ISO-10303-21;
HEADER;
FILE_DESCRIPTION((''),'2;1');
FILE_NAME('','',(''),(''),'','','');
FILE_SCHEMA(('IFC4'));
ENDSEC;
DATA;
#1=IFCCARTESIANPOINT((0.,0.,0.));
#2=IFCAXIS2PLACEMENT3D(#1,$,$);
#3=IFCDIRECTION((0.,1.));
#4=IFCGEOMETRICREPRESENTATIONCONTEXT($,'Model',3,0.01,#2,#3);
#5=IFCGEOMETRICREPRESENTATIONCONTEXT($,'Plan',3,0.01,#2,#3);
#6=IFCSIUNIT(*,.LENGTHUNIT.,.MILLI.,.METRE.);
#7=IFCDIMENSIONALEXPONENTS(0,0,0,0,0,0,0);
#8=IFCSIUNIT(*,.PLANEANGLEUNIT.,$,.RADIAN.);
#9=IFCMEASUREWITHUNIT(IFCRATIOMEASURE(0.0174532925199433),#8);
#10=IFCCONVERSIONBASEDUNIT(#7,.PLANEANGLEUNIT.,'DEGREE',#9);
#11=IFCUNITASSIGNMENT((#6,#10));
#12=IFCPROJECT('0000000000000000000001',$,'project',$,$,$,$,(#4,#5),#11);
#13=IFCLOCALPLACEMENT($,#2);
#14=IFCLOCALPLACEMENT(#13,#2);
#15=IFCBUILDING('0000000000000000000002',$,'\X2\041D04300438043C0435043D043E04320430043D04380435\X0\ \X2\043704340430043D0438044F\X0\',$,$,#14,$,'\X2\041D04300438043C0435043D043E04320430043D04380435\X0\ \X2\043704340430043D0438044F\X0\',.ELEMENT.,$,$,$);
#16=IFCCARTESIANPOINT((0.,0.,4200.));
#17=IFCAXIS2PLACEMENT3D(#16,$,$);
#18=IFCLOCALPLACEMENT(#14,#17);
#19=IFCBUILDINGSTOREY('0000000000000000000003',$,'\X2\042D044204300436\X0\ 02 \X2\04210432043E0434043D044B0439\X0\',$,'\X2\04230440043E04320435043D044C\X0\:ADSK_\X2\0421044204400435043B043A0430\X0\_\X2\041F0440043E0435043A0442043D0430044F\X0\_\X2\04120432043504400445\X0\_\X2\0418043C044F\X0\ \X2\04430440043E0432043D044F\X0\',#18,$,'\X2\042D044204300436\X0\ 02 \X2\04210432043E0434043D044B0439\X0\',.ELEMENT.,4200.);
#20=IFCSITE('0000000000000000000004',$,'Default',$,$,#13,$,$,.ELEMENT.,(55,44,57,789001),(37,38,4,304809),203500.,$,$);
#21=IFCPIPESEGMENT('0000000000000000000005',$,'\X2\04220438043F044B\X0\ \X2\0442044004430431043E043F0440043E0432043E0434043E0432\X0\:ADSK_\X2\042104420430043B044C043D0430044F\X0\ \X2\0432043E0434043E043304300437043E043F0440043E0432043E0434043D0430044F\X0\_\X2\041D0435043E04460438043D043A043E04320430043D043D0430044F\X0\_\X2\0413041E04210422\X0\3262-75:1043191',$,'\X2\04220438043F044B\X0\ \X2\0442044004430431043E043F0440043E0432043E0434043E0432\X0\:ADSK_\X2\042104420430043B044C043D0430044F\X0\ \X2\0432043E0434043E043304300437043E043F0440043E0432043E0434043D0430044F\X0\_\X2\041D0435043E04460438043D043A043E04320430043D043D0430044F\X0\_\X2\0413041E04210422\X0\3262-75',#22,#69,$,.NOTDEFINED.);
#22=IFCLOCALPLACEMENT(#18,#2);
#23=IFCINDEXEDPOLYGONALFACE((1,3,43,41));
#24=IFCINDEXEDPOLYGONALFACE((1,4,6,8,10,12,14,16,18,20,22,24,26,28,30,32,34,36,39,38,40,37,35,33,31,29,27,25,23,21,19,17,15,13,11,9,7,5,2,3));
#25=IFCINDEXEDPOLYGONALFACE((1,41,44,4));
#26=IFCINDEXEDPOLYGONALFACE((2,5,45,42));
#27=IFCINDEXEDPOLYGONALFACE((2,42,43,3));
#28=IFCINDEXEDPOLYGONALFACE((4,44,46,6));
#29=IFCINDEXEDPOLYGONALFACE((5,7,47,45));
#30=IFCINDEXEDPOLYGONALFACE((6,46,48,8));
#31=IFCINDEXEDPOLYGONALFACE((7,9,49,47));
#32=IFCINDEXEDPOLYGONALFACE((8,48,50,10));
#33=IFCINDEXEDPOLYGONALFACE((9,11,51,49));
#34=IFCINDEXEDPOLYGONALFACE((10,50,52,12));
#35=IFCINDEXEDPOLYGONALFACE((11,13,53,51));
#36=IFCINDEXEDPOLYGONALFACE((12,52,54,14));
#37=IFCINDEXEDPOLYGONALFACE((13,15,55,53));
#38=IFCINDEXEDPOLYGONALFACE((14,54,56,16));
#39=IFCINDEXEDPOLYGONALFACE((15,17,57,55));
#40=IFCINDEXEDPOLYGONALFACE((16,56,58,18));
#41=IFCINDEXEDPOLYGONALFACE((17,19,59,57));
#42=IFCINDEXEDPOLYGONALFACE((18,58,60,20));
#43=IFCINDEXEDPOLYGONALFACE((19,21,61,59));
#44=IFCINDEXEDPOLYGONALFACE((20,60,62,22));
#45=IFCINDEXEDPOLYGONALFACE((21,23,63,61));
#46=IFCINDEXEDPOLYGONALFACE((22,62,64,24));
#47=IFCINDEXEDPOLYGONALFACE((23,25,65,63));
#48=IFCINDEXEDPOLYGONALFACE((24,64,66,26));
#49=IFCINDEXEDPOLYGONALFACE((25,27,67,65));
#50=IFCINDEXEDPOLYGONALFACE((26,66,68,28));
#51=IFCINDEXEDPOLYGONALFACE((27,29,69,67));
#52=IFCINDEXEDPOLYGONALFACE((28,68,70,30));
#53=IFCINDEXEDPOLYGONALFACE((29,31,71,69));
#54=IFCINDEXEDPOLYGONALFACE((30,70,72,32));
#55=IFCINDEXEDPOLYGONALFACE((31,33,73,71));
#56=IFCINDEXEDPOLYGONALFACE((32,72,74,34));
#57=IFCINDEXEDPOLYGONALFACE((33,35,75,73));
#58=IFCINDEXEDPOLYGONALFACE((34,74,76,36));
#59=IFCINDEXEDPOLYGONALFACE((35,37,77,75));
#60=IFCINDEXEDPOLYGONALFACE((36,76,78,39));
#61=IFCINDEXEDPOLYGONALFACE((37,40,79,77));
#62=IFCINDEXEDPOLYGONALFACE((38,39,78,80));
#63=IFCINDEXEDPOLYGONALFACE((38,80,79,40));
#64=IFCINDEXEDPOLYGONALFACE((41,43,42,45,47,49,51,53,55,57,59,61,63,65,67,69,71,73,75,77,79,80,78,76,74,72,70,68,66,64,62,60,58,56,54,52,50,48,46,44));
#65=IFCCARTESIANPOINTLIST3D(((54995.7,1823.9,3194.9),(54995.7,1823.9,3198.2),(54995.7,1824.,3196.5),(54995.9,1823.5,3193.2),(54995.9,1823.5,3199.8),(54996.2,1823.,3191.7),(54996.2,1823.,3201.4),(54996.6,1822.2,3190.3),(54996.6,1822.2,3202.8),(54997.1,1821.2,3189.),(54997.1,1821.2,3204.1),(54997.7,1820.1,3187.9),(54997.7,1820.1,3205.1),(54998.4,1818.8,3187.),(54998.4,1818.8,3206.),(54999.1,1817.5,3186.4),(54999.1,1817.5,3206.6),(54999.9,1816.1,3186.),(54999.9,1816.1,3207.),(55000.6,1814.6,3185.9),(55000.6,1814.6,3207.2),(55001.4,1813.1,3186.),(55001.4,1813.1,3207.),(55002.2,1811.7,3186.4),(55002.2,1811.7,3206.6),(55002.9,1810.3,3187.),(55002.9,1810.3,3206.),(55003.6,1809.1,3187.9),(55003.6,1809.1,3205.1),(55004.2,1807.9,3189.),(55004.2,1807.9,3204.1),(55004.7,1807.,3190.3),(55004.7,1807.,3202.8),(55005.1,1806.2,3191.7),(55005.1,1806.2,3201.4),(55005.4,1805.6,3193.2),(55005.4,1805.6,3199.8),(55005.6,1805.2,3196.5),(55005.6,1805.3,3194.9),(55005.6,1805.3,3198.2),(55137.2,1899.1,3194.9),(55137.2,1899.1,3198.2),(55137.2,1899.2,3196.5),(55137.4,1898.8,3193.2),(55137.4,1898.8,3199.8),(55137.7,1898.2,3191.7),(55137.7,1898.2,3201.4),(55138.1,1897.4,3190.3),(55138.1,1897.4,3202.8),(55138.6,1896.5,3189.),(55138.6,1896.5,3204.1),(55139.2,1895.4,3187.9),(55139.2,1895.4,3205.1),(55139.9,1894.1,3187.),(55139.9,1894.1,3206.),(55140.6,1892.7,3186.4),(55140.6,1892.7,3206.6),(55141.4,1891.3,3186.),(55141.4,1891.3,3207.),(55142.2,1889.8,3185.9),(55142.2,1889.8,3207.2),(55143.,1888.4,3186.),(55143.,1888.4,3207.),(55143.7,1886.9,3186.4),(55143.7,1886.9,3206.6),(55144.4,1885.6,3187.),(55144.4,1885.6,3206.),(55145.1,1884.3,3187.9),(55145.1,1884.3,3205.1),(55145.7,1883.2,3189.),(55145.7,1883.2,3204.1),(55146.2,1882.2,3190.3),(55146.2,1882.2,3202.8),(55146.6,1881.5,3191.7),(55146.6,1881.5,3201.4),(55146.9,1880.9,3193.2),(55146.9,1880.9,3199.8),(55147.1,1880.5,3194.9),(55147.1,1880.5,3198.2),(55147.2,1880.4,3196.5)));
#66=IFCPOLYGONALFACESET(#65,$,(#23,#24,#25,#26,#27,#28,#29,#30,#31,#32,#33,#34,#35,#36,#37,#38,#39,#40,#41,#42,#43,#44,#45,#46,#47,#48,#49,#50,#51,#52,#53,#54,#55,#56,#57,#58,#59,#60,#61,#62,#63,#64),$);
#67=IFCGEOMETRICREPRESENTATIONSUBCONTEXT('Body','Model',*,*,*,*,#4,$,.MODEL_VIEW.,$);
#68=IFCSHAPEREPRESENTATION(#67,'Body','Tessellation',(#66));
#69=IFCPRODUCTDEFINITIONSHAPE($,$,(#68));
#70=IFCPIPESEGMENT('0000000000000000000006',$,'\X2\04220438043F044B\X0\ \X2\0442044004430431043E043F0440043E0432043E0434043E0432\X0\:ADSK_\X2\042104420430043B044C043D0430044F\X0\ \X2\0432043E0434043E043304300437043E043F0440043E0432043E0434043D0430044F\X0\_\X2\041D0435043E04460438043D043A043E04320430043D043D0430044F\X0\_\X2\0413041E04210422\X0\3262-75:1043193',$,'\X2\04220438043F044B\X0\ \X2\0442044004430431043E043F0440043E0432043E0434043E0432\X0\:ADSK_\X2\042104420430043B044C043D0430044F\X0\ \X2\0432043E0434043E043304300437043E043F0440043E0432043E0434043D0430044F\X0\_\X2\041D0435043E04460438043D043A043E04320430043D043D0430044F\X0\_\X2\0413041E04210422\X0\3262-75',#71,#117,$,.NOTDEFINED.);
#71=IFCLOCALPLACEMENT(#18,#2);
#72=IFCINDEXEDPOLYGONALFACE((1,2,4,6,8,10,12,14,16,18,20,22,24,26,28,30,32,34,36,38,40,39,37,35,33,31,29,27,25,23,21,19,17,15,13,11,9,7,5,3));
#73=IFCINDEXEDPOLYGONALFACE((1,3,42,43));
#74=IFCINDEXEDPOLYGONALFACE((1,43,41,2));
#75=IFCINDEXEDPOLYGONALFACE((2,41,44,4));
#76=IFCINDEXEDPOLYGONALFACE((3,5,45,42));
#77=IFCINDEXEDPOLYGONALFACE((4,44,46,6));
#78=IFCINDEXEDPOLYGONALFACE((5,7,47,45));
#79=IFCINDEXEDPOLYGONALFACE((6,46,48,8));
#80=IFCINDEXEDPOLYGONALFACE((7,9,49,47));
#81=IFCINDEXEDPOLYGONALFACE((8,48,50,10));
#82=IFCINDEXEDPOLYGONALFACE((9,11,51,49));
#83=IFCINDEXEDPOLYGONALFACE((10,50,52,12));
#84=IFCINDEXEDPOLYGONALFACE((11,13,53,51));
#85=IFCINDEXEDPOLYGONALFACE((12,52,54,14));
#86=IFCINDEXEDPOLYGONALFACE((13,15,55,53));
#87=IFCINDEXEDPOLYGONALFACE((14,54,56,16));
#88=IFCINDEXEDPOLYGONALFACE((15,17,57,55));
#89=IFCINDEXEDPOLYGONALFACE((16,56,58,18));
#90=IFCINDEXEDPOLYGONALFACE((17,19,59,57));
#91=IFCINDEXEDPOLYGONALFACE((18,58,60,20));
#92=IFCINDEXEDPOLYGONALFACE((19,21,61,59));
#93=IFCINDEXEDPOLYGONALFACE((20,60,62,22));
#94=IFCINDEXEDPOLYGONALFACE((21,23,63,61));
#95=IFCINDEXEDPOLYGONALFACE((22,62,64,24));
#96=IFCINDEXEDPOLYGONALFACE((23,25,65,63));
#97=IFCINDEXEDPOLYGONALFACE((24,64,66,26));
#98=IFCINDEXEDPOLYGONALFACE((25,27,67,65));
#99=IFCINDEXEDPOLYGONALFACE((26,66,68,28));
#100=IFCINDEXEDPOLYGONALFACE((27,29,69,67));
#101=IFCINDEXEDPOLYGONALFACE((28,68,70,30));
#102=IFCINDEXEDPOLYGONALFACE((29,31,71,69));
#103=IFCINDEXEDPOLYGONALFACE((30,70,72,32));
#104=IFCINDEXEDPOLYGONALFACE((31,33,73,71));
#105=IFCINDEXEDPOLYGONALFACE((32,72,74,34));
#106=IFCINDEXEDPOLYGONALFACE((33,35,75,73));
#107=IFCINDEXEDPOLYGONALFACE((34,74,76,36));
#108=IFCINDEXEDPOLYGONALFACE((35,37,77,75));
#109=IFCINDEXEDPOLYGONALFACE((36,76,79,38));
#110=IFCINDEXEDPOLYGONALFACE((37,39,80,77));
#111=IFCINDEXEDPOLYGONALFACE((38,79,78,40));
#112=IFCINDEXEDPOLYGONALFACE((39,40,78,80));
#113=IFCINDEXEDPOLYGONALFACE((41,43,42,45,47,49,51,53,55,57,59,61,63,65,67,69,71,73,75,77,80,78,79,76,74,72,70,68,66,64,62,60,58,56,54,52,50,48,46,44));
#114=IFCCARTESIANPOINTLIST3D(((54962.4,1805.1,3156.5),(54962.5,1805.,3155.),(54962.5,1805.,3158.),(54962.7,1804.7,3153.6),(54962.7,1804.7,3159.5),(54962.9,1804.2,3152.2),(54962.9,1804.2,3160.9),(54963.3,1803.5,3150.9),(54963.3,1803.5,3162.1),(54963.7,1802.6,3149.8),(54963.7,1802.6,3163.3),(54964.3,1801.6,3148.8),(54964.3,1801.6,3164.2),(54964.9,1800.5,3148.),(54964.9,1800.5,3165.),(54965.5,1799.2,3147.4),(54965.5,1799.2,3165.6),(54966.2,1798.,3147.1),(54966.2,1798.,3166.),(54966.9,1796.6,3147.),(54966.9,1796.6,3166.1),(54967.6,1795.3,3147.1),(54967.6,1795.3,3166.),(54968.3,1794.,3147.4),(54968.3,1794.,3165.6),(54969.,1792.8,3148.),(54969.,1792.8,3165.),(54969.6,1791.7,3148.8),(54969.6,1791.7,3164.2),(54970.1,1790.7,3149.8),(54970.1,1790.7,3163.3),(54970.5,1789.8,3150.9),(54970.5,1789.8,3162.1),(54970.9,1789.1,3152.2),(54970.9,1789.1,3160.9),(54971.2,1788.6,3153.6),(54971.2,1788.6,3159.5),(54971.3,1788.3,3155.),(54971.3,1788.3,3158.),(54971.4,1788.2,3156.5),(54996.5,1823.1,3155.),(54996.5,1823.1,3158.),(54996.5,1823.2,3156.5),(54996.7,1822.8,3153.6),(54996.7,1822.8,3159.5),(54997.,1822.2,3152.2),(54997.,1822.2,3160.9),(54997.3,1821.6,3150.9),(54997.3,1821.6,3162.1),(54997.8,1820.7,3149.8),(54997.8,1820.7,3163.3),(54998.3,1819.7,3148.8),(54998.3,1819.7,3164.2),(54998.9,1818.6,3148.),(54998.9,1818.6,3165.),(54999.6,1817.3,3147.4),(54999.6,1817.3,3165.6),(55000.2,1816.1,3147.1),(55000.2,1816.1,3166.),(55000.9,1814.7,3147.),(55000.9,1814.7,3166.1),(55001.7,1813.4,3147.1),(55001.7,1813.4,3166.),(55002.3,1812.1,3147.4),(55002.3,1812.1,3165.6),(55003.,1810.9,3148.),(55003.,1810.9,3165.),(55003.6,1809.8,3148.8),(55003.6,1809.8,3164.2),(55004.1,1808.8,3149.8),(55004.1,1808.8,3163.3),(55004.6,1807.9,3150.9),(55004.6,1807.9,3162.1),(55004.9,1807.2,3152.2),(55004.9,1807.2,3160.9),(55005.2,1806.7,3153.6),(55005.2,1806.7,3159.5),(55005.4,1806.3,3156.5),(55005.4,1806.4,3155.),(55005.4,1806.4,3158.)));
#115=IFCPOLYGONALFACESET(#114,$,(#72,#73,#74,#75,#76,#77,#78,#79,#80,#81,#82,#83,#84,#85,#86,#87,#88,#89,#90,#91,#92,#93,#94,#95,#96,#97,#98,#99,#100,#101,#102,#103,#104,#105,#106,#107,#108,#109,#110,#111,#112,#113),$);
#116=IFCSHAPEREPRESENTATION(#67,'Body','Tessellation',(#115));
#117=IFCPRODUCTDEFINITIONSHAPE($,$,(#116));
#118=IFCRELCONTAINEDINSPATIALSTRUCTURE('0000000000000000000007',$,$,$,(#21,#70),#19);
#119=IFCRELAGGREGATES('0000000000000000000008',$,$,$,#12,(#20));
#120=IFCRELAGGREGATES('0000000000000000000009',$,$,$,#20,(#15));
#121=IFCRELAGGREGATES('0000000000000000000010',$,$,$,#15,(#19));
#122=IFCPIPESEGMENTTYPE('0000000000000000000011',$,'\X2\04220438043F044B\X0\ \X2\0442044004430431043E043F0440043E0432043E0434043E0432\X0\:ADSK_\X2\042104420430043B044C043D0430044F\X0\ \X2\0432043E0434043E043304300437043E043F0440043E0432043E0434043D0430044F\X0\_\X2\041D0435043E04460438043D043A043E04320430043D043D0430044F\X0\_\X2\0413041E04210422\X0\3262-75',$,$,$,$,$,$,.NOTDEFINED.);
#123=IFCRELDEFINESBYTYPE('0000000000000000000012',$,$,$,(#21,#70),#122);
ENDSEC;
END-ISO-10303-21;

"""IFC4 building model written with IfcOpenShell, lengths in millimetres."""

from ifc_helpers import new_model, entity, si_unit, converted_unit, direction, frame, origin, place, context, subcontext, project, spatial, indexed_curve, outline, extrude, type_object, element, save


model = new_model("IFC4")

# Units and contexts
model_context = context("Model", 3, precision=0.01, world=origin(), true_north=direction((0.0, 1.0)))
plan_context = context("Plan", 3, precision=0.01, world=origin(), true_north=direction((0.0, 1.0)))
body_context = subcontext(model_context, "Body", "Model", "MODEL_VIEW")
ifc_project = project(units=[si_unit("LENGTHUNIT", "METRE", prefix="MILLI"), converted_unit("PLANEANGLEUNIT", "DEGREE", entity("IfcRatioMeasure", 0.0174532925199433), si_unit("PLANEANGLEUNIT", "RADIAN"), dimensions=[0, 0, 0, 0, 0, 0, 0])], contexts=[model_context, plan_context])

# Site, building, storey
site_placement = place(None, origin())
site = spatial("IfcSite", under=ifc_project, at=site_placement, Name="Default", CompositionType="ELEMENT", RefLatitude=(55, 44, 57, 789001), RefLongitude=(37, 38, 4, 304809), RefElevation=203500.0)
building_placement = place(site_placement, origin())
building = spatial("IfcBuilding", under=site, at=building_placement, Name="Наименование здания", LongName="Наименование здания", CompositionType="ELEMENT")
storey_placement = place(building_placement, frame((0.0, 0.0, 4200.0)))
storey = spatial("IfcBuildingStorey", under=building, at=storey_placement, Name="Этаж 02 Сводный", ObjectType="Уровень:ADSK_Стрелка_Проектная_Вверх_Имя уровня", LongName="Этаж 02 Сводный", CompositionType="ELEMENT", Elevation=4200.0)

# Pipe segments
pipe_segment_type = type_object("IfcPipeSegmentType", Name="Типы трубопроводов:ADSK_Стальная водогазопроводная_Неоцинкованная_ГОСТ3262-75", PredefinedType="NOTDEFINED")
placement = place(storey_placement, origin())
element("IfcPipeSegment", 1, at=placement, inside=storey, type_object=pipe_segment_type, Name="Типы трубопроводов:ADSK_Стальная водогазопроводная_Неоцинкованная_ГОСТ3262-75:1043191", ObjectType="Типы трубопроводов:ADSK_Стальная водогазопроводная_Неоцинкованная_ГОСТ3262-75", PredefinedType="NOTDEFINED", context=body_context, shape_type="SweptSolid", body=[
    extrude(outline(indexed_curve([(10.6, 0.0), (10.5, 1.7), (10.1, 3.3), (9.5, 4.8), (8.6, 6.3), (7.5, 7.5), (6.3, 8.6), (4.8, 9.5), (3.3, 10.1), (1.7, 10.5), (0.0, 10.6), (-1.7, 10.5), (-3.3, 10.1), (-4.8, 9.5), (-6.3, 8.6), (-7.5, 7.5), (-8.6, 6.3), (-9.5, 4.8), (-10.1, 3.3), (-10.5, 1.7), (-10.6, 0.0), (-10.5, -1.7), (-10.1, -3.3), (-9.5, -4.8), (-8.6, -6.3), (-7.5, -7.5), (-6.3, -8.6), (-4.8, -9.5), (-3.3, -10.1), (-1.7, -10.5), (0.0, -10.6), (1.7, -10.5), (3.3, -10.1), (4.8, -9.5), (6.3, -8.6), (7.5, -7.5), (8.6, -6.3), (9.5, -4.8), (10.1, -3.3), (10.5, -1.7), (10.6, 0.0)], self_intersect=False)), frame((55000.7, 1814.6, 3196.5), z_axis=(0.882948, 0.469472, 0.0), x_axis=(0.469472, -0.882948, 0.0)), (0.0, 0.0, 1.0), 160.3),
])
element("IfcPipeSegment", 2, at=placement, inside=storey, type_object=pipe_segment_type, Name="Типы трубопроводов:ADSK_Стальная водогазопроводная_Неоцинкованная_ГОСТ3262-75:1043193", ObjectType="Типы трубопроводов:ADSK_Стальная водогазопроводная_Неоцинкованная_ГОСТ3262-75", PredefinedType="NOTDEFINED", context=body_context, shape_type="SweptSolid", body=[
    extrude(outline(indexed_curve([(9.6, 0.0), (9.4, 1.5), (9.1, 3.0), (8.5, 4.3), (7.7, 5.6), (6.8, 6.8), (5.6, 7.7), (4.3, 8.5), (3.0, 9.1), (1.5, 9.4), (0.0, 9.6), (-1.5, 9.4), (-3.0, 9.1), (-4.3, 8.5), (-5.6, 7.7), (-6.8, 6.8), (-7.7, 5.6), (-8.5, 4.3), (-9.1, 3.0), (-9.4, 1.5), (-9.6, 0.0), (-9.4, -1.5), (-9.1, -3.0), (-8.5, -4.3), (-7.7, -5.6), (-6.8, -6.8), (-5.6, -7.7), (-4.3, -8.5), (-3.0, -9.1), (-1.5, -9.4), (0.0, -9.6), (1.5, -9.4), (3.0, -9.1), (4.3, -8.5), (5.6, -7.7), (6.8, -6.8), (7.7, -5.6), (8.5, -4.3), (9.1, -3.0), (9.4, -1.5), (9.6, 0.0)], self_intersect=False)), frame((54966.9, 1796.6, 3156.5), z_axis=(0.882948, 0.469472, 0.0), x_axis=(0.469472, -0.882948, 0.0)), (0.0, 0.0, 1.0), 38.5),
])

save(model, "model.ifc")
